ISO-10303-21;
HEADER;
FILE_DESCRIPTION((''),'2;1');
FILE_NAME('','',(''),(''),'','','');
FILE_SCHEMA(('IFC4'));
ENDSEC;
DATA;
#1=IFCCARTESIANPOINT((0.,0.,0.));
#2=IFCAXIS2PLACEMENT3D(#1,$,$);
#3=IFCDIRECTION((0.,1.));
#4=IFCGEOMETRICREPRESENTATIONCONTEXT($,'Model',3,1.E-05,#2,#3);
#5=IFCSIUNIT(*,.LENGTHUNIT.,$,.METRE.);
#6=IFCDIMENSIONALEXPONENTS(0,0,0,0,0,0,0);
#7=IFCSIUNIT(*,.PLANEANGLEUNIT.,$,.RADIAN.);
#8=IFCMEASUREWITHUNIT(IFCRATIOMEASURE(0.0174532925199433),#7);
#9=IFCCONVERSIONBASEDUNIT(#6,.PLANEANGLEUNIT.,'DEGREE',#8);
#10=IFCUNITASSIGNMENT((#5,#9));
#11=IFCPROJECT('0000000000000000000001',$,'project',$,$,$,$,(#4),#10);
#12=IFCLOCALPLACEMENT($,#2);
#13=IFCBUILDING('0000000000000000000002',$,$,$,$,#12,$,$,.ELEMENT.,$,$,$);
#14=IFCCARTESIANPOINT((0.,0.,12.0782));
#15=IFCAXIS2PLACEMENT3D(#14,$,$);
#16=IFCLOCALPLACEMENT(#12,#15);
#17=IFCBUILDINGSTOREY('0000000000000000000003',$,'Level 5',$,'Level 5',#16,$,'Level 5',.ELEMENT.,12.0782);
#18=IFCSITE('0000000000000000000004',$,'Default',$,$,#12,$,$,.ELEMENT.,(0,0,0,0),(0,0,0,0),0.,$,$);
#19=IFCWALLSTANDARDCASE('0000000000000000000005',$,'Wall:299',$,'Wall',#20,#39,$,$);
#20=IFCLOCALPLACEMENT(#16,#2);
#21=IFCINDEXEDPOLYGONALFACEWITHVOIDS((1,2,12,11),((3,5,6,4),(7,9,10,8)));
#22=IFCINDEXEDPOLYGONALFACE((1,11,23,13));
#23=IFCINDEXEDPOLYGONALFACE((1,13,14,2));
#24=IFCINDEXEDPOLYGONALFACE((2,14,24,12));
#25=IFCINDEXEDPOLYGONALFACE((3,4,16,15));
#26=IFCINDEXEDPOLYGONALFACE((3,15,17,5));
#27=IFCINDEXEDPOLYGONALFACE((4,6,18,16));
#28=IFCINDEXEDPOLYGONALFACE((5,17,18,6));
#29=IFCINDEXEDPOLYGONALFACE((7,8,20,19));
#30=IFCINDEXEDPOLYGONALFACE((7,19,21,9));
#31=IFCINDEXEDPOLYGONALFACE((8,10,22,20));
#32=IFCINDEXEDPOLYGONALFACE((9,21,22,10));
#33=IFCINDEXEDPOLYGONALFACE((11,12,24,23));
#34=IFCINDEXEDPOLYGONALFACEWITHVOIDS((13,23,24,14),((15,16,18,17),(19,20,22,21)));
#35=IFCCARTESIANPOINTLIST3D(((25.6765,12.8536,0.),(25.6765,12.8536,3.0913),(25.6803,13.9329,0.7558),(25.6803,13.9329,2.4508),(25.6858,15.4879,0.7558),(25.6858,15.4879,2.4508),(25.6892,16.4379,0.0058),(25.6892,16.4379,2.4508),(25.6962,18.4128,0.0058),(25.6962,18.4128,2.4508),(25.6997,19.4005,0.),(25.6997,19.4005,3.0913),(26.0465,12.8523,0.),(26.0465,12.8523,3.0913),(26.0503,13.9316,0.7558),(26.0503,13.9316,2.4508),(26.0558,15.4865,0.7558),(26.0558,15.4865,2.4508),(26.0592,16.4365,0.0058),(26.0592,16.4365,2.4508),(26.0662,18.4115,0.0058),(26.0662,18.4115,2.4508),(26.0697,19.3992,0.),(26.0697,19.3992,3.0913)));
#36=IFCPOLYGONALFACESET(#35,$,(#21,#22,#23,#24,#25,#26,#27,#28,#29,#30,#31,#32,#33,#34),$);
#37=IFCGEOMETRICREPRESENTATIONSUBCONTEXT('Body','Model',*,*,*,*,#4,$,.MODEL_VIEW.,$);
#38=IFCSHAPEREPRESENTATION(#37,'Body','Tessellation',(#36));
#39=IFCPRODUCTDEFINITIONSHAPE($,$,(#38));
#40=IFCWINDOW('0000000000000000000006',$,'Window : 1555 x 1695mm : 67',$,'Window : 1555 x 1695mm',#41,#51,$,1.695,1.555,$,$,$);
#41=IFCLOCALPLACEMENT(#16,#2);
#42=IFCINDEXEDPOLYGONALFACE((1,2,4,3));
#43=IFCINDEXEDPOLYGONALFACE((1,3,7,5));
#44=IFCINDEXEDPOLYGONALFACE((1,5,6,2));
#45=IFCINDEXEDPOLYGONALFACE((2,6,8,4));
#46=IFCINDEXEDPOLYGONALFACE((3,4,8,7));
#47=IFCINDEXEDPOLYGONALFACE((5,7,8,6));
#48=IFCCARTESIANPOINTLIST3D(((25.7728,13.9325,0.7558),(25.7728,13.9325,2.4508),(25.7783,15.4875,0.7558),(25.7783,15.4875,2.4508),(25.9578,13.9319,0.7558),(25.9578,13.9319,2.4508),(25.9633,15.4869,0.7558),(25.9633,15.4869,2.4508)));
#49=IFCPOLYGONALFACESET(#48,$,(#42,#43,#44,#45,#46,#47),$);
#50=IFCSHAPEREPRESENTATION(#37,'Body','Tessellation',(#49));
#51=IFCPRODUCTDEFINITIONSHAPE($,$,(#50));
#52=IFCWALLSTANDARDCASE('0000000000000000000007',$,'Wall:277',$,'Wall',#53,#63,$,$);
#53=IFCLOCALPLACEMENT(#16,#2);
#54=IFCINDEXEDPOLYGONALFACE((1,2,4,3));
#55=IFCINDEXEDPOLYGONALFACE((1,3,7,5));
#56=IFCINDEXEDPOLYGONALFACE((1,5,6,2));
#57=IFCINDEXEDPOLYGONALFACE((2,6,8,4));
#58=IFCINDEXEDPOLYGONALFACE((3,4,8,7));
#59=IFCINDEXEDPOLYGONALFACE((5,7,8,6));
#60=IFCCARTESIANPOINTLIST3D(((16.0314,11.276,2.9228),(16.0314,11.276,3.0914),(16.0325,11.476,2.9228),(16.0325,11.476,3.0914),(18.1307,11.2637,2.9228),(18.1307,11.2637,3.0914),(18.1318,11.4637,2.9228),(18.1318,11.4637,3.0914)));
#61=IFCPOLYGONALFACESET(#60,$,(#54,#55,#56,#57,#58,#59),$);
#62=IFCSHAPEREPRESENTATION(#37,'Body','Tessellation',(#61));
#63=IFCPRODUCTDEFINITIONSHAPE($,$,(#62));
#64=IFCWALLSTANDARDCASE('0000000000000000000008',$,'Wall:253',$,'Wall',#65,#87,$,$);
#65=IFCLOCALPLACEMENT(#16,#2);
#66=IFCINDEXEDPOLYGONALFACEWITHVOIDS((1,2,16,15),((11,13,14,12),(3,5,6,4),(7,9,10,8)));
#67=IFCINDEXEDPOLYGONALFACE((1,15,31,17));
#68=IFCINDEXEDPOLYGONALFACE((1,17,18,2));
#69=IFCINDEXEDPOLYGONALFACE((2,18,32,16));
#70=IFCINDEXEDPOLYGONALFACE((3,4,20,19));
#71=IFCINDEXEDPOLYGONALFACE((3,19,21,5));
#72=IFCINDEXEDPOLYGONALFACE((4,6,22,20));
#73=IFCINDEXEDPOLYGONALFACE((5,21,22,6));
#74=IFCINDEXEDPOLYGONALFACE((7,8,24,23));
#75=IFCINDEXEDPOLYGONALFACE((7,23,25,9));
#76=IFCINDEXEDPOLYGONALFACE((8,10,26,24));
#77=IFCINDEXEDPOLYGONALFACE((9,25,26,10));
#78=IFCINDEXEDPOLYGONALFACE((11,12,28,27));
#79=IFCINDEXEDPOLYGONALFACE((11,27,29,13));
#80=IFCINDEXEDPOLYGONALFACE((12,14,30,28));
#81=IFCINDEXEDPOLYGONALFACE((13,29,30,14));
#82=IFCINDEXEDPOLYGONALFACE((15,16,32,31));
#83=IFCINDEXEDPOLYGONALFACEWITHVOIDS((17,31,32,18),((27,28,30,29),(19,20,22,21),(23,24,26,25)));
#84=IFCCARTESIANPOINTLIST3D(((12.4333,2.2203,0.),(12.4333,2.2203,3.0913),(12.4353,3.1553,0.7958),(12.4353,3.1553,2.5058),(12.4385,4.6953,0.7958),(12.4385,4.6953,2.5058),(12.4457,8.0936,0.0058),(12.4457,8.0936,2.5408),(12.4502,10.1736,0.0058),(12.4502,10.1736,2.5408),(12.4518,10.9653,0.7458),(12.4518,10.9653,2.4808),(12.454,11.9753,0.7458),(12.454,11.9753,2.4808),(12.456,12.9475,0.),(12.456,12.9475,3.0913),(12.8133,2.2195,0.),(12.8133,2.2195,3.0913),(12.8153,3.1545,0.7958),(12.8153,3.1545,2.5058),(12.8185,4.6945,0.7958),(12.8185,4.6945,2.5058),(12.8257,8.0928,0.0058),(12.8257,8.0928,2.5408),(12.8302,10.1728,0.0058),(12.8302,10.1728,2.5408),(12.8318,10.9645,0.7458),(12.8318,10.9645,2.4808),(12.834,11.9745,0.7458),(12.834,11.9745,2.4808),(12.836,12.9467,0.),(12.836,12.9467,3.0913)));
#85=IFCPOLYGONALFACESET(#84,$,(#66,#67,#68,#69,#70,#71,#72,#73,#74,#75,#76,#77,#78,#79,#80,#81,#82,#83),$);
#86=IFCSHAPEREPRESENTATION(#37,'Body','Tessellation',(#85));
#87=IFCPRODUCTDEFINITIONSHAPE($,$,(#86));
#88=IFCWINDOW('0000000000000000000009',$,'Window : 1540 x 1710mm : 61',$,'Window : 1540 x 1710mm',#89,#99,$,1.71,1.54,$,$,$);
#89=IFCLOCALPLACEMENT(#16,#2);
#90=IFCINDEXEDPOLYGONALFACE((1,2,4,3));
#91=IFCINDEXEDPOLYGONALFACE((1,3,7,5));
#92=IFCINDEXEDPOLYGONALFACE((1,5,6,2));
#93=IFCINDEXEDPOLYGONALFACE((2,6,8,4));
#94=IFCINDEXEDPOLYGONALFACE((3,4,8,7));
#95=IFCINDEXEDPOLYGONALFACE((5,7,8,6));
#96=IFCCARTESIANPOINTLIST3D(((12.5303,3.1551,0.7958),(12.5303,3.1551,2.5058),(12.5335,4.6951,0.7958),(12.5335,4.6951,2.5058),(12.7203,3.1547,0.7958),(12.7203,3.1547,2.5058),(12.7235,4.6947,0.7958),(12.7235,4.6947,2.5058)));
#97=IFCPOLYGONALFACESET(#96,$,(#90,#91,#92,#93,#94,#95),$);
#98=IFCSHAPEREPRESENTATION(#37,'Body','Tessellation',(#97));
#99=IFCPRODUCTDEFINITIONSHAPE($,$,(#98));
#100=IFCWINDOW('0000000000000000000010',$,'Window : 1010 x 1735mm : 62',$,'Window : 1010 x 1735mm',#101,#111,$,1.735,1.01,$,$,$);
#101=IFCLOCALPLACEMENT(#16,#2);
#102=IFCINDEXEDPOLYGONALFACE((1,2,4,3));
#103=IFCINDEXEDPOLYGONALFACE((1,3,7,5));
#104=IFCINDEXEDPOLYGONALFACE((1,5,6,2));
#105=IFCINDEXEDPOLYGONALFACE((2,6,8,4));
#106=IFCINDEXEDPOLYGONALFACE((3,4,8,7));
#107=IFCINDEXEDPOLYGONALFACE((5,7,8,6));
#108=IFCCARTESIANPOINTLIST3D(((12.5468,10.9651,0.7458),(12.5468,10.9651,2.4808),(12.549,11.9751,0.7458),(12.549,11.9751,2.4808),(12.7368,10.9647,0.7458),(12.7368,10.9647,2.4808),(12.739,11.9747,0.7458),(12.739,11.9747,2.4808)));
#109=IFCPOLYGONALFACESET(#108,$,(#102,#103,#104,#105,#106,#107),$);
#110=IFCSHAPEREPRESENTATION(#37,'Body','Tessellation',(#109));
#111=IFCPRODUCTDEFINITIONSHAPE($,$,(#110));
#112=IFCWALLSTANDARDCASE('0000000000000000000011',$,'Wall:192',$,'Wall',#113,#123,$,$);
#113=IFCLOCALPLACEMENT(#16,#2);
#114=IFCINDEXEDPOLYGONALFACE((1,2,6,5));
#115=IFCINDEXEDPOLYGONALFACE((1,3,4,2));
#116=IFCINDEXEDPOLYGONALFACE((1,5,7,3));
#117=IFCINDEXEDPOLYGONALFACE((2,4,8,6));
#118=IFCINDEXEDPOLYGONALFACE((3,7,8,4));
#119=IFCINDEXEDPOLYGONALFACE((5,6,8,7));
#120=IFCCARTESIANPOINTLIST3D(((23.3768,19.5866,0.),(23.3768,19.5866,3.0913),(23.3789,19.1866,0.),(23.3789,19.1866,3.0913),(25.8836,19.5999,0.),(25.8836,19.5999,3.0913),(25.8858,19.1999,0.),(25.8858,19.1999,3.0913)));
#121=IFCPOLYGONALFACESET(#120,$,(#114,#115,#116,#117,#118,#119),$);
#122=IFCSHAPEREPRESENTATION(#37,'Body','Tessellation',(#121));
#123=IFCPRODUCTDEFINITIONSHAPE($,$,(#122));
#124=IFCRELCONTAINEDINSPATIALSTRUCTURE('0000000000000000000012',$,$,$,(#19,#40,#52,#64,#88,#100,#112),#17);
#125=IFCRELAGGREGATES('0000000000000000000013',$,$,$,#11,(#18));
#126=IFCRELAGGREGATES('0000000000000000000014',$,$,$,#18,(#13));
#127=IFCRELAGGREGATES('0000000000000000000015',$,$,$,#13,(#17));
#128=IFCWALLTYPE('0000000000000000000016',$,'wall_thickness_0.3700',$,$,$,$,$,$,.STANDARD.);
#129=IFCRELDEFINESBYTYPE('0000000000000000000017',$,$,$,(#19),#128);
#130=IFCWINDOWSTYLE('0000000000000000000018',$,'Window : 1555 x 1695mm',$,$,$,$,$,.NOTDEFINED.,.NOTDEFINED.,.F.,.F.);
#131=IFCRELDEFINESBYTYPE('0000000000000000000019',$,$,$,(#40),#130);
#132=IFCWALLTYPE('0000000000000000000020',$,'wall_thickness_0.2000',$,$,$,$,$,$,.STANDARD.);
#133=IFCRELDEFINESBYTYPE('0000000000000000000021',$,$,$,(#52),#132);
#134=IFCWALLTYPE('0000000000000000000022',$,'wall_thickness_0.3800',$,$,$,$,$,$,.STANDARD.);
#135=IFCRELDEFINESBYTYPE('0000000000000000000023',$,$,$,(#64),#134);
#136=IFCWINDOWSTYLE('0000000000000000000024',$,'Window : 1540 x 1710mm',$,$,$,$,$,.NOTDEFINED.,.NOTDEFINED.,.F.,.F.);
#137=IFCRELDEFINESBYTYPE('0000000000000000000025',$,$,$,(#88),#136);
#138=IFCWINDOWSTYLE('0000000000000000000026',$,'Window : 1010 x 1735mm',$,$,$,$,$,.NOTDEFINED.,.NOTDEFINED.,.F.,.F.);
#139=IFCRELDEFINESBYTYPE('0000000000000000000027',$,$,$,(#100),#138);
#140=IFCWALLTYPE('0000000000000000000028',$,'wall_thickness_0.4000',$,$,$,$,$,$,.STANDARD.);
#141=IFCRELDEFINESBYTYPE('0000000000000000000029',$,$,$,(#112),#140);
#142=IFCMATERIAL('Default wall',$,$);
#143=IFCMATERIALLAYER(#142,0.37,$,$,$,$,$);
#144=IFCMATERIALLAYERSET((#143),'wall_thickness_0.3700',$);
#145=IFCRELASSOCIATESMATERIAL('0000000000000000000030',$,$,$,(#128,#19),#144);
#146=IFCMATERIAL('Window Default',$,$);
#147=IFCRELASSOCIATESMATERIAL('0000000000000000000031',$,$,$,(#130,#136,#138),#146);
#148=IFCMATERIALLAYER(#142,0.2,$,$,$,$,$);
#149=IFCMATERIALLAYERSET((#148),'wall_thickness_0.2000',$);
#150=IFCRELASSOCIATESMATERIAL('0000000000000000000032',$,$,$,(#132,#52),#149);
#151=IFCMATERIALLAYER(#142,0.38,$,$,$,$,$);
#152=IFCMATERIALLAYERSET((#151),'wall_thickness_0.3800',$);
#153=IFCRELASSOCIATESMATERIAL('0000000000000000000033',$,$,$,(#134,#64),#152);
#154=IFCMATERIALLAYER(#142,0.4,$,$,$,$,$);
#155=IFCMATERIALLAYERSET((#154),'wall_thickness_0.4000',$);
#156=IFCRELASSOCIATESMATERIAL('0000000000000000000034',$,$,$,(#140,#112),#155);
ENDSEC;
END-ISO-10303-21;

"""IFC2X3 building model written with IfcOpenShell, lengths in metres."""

from ifc_helpers import new_model, entity, si_unit, converted_unit, direction, frame, frame_2d, origin, origin_2d_with_axis, place, context, subcontext, project, spatial, polyline, rectangle, outline, extrude, clip, halfspace, source, transform, mapped, material, layer, layer_set, layer_usage, type_object, type_shapes, element, fill, save


model = new_model("IFC2X3")

# Units and contexts
model_context = context("Model", 3, precision=1e-05, world=origin(), true_north=direction((0.0, 1.0)))
body_context = subcontext(model_context, "Body", "Model", "MODEL_VIEW")
ifc_project = project(units=[si_unit("LENGTHUNIT", "METRE"), converted_unit("PLANEANGLEUNIT", "DEGREE", entity("IfcRatioMeasure", 0.0174532925199433), si_unit("PLANEANGLEUNIT", "RADIAN"), dimensions=[0, 0, 0, 0, 0, 0, 0])], contexts=[model_context])

# Site, building, storey
placement_1 = place(None, origin())
site = spatial("IfcSite", under=ifc_project, at=placement_1, Name="Default", CompositionType="ELEMENT", RefLatitude=(0, 0, 0, 0), RefLongitude=(0, 0, 0, 0), RefElevation=0.0)
building = spatial("IfcBuilding", under=site, at=placement_1, CompositionType="ELEMENT")
storey_placement = place(placement_1, frame((0.0, 0.0, 12.0782)))
storey = spatial("IfcBuildingStorey", under=building, at=storey_placement, Name="Level 5", ObjectType="Level 5", LongName="Level 5", CompositionType="ELEMENT", Elevation=12.0782)

# Shared definitions
ifc_material_1 = material(Name="Default wall")

# Wall, openings, window
ifc_layer_1 = layer(ifc_material_1, 0.37)
ifc_layer_set_1 = layer_set([ifc_layer_1], Name="wall_thickness_0.3700")
ifc_layer_usage_1 = layer_usage(ifc_layer_set_1, "AXIS2", "POSITIVE", -0.185)
wall_type_1 = type_object("IfcWallType", Name="wall_thickness_0.3700", PredefinedType="STANDARD", material=ifc_layer_set_1)
wall_1_placement = place(storey_placement, frame((25.8847, 19.3999, 0.0), z_axis=(0.0, 0.0, 1.0), x_axis=(-0.003547, -0.999994, 0.0)))
wall_1 = element("IfcWallStandardCase", 1, at=wall_1_placement, inside=storey, type_object=wall_type_1, material=ifc_layer_usage_1, Name="Wall:299", ObjectType="Wall", context=body_context, shape_type="SweptSolid", body=[
    extrude(outline(polyline([(6.547, -0.185), (6.547, 0.185), (0.0, 0.185), (0.0, -0.185), (6.547, -0.185)])), origin(), (0.0, 0.0, 1.0), 3.0913),
])
opening_1_placement = place(wall_1_placement, frame((0.9877, -0.185, 0.0058)))
element("IfcOpeningElement", 2, at=opening_1_placement, cuts=wall_1, ObjectType="Opening", context=body_context, shape_type="SweptSolid", body=[
    extrude(rectangle(XDim=1.975, YDim=2.445, at=frame_2d((1.2225, 0.9875), x_axis=(0.0, 1.0))), frame((0.0, 0.0, 0.0), z_axis=(0.0, 1.0, 0.0), x_axis=(0.0, 0.0, 1.0)), (0.0, 0.0, 1.0), 0.37),
])
opening_2_placement = place(wall_1_placement, frame((3.9127, -0.185, 0.7558)))
opening_2 = element("IfcOpeningElement", 3, at=opening_2_placement, cuts=wall_1, ObjectType="Opening", context=body_context, shape_type="SweptSolid", body=[
    extrude(rectangle(XDim=1.555, YDim=1.695, at=frame_2d((0.8475, 0.7775), x_axis=(0.0, 1.0))), frame((0.0, 0.0, 0.0), z_axis=(0.0, 1.0, 0.0), x_axis=(0.0, 0.0, 1.0)), (0.0, 0.0, 1.0), 0.37),
])
ifc_material_2 = material(Name="Window Default")
window_style_1 = type_object("IfcWindowStyle", Name="Window : 1555 x 1695mm", ConstructionType="NOTDEFINED", OperationType="NOTDEFINED", ParameterTakesPrecedence=False, Sizeable=False, material=ifc_material_2)
shared_shape_1 = source(origin(), body_context, "Body", "SweptSolid", [
    extrude(rectangle(XDim=0.185, YDim=1.555, at=origin_2d_with_axis()), frame((0.7775, 0.185, 0.0), z_axis=(0.0, 0.0, 1.0), x_axis=(0.0, 1.0, 0.0)), (0.0, 0.0, 1.0), 1.695),
])
type_shapes(window_style_1, [shared_shape_1])
window_1_placement = place(opening_2_placement, origin())
window_1 = element("IfcWindow", 4, at=window_1_placement, inside=storey, type_object=window_style_1, Name="Window : 1555 x 1695mm : 67", ObjectType="Window : 1555 x 1695mm", OverallHeight=1.695, OverallWidth=1.555, context=body_context, shape_type="MappedRepresentation", body=[
    mapped(shared_shape_1, transform((0.0, 0.0, 0.0), scale=1.0)),
])
fill(opening_2, window_1)

# Wall
ifc_layer_2 = layer(ifc_material_1, 0.2)
ifc_layer_set_2 = layer_set([ifc_layer_2], Name="wall_thickness_0.2000")
ifc_layer_usage_2 = layer_usage(ifc_layer_set_2, "AXIS2", "POSITIVE", -0.1)
wall_type_2 = type_object("IfcWallType", Name="wall_thickness_0.2000", PredefinedType="STANDARD", material=ifc_layer_set_2)
placement_2 = place(placement_1, frame((0.0, 0.0, 15.001)))
wall_2_placement = place(placement_2, frame((16.0319, 11.376, 0.0), z_axis=(0.0, 0.0, 1.0), x_axis=(0.999983, -0.005856, 0.0)))
element("IfcWallStandardCase", 5, at=wall_2_placement, inside=storey, type_object=wall_type_2, material=ifc_layer_usage_2, Name="Wall:277", ObjectType="Wall", context=body_context, shape_type="SweptSolid", body=[
    extrude(outline(polyline([(2.0994, -0.1), (2.0994, 0.1), (0.0, 0.1), (0.0, -0.1), (2.0994, -0.1)])), origin(), (0.0, 0.0, 1.0), 0.1686),
])

# Wall, openings, windows
ifc_layer_3 = layer(ifc_material_1, 0.38)
ifc_layer_set_3 = layer_set([ifc_layer_3], Name="wall_thickness_0.3800")
ifc_layer_usage_3 = layer_usage(ifc_layer_set_3, "AXIS2", "POSITIVE", -0.19)
wall_type_3 = type_object("IfcWallType", Name="wall_thickness_0.3800", PredefinedType="STANDARD", material=ifc_layer_set_3)
wall_3_placement = place(storey_placement, frame((12.646, 12.9471, 0.0), z_axis=(0.0, 0.0, 1.0), x_axis=(-0.002122, -0.999998, 0.0)))
wall_3 = element("IfcWallStandardCase", 6, at=wall_3_placement, inside=storey, type_object=wall_type_3, material=ifc_layer_usage_3, Name="Wall:253", ObjectType="Wall", context=body_context, shape_type="Clipping", body=[
    clip(extrude(outline(polyline([(10.7272, -0.19), (10.7272, 0.19), (0.0, 0.19), (0.0, -0.19), (10.7272, -0.19)])), origin(), (0.0, 0.0, 1.0), 3.0913), halfspace(frame((-64.2893, 1.2997, 5.8218), z_axis=(0.001075, 0.390504, 0.920601), x_axis=(-0.002039, -0.920598, 0.390505)), False)),
])
opening_3_placement = place(wall_3_placement, frame((2.774, -0.19, 0.0058)))
element("IfcOpeningElement", 7, at=opening_3_placement, cuts=wall_3, ObjectType="Opening", context=body_context, shape_type="SweptSolid", body=[
    extrude(rectangle(XDim=2.08, YDim=2.535, at=frame_2d((1.2675, 1.04), x_axis=(0.0, 1.0))), frame((0.0, 0.0, 0.0), z_axis=(0.0, 1.0, 0.0), x_axis=(0.0, 0.0, 1.0)), (0.0, 0.0, 1.0), 0.38),
])
opening_4_placement = place(wall_3_placement, frame((8.2522, -0.19, 0.7958)))
opening_4 = element("IfcOpeningElement", 8, at=opening_4_placement, cuts=wall_3, ObjectType="Opening", context=body_context, shape_type="SweptSolid", body=[
    extrude(rectangle(XDim=1.54, YDim=1.71, at=frame_2d((0.855, 0.77), x_axis=(0.0, 1.0))), frame((0.0, 0.0, 0.0), z_axis=(0.0, 1.0, 0.0), x_axis=(0.0, 0.0, 1.0)), (0.0, 0.0, 1.0), 0.38),
])
opening_5_placement = place(wall_3_placement, frame((0.9722, -0.19, 0.7458)))
opening_5 = element("IfcOpeningElement", 9, at=opening_5_placement, cuts=wall_3, ObjectType="Opening", context=body_context, shape_type="SweptSolid", body=[
    extrude(rectangle(XDim=1.01, YDim=1.735, at=frame_2d((0.8675, 0.505), x_axis=(0.0, 1.0))), frame((0.0, 0.0, 0.0), z_axis=(0.0, 1.0, 0.0), x_axis=(0.0, 0.0, 1.0)), (0.0, 0.0, 1.0), 0.38),
])
window_style_2 = type_object("IfcWindowStyle", Name="Window : 1540 x 1710mm", ConstructionType="NOTDEFINED", OperationType="NOTDEFINED", ParameterTakesPrecedence=False, Sizeable=False, material=ifc_material_2)
shared_shape_2 = source(origin(), body_context, "Body", "SweptSolid", [
    extrude(rectangle(XDim=0.19, YDim=1.54, at=origin_2d_with_axis()), frame((0.77, 0.19, 0.0), z_axis=(0.0, 0.0, 1.0), x_axis=(0.0, 1.0, 0.0)), (0.0, 0.0, 1.0), 1.71),
])
type_shapes(window_style_2, [shared_shape_2])
window_2_placement = place(opening_4_placement, origin())
window_2 = element("IfcWindow", 10, at=window_2_placement, inside=storey, type_object=window_style_2, Name="Window : 1540 x 1710mm : 61", ObjectType="Window : 1540 x 1710mm", OverallHeight=1.71, OverallWidth=1.54, context=body_context, shape_type="MappedRepresentation", body=[
    mapped(shared_shape_2, transform((0.0, 0.0, 0.0), scale=1.0)),
])
fill(opening_4, window_2)
window_style_3 = type_object("IfcWindowStyle", Name="Window : 1010 x 1735mm", ConstructionType="NOTDEFINED", OperationType="NOTDEFINED", ParameterTakesPrecedence=False, Sizeable=False, material=ifc_material_2)
shared_shape_3 = source(origin(), body_context, "Body", "SweptSolid", [
    extrude(rectangle(XDim=0.19, YDim=1.01, at=origin_2d_with_axis()), frame((0.505, 0.19, 0.0), z_axis=(0.0, 0.0, 1.0), x_axis=(0.0, 1.0, 0.0)), (0.0, 0.0, 1.0), 1.735),
])
type_shapes(window_style_3, [shared_shape_3])
window_3_placement = place(opening_5_placement, origin())
window_3 = element("IfcWindow", 11, at=window_3_placement, inside=storey, type_object=window_style_3, Name="Window : 1010 x 1735mm : 62", ObjectType="Window : 1010 x 1735mm", OverallHeight=1.735, OverallWidth=1.01, context=body_context, shape_type="MappedRepresentation", body=[
    mapped(shared_shape_3, transform((0.0, 0.0, 0.0), scale=1.0)),
])
fill(opening_5, window_3)

# Wall
ifc_layer_4 = layer(ifc_material_1, 0.4)
ifc_layer_set_4 = layer_set([ifc_layer_4], Name="wall_thickness_0.4000")
ifc_layer_usage_4 = layer_usage(ifc_layer_set_4, "AXIS2", "POSITIVE", -0.2)
wall_type_4 = type_object("IfcWallType", Name="wall_thickness_0.4000", PredefinedType="STANDARD", material=ifc_layer_set_4)
wall_4_placement = place(storey_placement, frame((23.3778, 19.3866, 0.0), z_axis=(0.0, 0.0, 1.0), x_axis=(0.999986, 0.005305, 0.0)))
element("IfcWallStandardCase", 12, at=wall_4_placement, inside=storey, type_object=wall_type_4, material=ifc_layer_usage_4, Name="Wall:192", ObjectType="Wall", context=body_context, shape_type="SweptSolid", body=[
    extrude(outline(polyline([(2.5069, -0.2), (2.5069, 0.2), (0.0, 0.2), (0.0, -0.2), (2.5069, -0.2)])), origin(), (0.0, 0.0, 1.0), 3.0913),
])

save(model, "model.ifc")
